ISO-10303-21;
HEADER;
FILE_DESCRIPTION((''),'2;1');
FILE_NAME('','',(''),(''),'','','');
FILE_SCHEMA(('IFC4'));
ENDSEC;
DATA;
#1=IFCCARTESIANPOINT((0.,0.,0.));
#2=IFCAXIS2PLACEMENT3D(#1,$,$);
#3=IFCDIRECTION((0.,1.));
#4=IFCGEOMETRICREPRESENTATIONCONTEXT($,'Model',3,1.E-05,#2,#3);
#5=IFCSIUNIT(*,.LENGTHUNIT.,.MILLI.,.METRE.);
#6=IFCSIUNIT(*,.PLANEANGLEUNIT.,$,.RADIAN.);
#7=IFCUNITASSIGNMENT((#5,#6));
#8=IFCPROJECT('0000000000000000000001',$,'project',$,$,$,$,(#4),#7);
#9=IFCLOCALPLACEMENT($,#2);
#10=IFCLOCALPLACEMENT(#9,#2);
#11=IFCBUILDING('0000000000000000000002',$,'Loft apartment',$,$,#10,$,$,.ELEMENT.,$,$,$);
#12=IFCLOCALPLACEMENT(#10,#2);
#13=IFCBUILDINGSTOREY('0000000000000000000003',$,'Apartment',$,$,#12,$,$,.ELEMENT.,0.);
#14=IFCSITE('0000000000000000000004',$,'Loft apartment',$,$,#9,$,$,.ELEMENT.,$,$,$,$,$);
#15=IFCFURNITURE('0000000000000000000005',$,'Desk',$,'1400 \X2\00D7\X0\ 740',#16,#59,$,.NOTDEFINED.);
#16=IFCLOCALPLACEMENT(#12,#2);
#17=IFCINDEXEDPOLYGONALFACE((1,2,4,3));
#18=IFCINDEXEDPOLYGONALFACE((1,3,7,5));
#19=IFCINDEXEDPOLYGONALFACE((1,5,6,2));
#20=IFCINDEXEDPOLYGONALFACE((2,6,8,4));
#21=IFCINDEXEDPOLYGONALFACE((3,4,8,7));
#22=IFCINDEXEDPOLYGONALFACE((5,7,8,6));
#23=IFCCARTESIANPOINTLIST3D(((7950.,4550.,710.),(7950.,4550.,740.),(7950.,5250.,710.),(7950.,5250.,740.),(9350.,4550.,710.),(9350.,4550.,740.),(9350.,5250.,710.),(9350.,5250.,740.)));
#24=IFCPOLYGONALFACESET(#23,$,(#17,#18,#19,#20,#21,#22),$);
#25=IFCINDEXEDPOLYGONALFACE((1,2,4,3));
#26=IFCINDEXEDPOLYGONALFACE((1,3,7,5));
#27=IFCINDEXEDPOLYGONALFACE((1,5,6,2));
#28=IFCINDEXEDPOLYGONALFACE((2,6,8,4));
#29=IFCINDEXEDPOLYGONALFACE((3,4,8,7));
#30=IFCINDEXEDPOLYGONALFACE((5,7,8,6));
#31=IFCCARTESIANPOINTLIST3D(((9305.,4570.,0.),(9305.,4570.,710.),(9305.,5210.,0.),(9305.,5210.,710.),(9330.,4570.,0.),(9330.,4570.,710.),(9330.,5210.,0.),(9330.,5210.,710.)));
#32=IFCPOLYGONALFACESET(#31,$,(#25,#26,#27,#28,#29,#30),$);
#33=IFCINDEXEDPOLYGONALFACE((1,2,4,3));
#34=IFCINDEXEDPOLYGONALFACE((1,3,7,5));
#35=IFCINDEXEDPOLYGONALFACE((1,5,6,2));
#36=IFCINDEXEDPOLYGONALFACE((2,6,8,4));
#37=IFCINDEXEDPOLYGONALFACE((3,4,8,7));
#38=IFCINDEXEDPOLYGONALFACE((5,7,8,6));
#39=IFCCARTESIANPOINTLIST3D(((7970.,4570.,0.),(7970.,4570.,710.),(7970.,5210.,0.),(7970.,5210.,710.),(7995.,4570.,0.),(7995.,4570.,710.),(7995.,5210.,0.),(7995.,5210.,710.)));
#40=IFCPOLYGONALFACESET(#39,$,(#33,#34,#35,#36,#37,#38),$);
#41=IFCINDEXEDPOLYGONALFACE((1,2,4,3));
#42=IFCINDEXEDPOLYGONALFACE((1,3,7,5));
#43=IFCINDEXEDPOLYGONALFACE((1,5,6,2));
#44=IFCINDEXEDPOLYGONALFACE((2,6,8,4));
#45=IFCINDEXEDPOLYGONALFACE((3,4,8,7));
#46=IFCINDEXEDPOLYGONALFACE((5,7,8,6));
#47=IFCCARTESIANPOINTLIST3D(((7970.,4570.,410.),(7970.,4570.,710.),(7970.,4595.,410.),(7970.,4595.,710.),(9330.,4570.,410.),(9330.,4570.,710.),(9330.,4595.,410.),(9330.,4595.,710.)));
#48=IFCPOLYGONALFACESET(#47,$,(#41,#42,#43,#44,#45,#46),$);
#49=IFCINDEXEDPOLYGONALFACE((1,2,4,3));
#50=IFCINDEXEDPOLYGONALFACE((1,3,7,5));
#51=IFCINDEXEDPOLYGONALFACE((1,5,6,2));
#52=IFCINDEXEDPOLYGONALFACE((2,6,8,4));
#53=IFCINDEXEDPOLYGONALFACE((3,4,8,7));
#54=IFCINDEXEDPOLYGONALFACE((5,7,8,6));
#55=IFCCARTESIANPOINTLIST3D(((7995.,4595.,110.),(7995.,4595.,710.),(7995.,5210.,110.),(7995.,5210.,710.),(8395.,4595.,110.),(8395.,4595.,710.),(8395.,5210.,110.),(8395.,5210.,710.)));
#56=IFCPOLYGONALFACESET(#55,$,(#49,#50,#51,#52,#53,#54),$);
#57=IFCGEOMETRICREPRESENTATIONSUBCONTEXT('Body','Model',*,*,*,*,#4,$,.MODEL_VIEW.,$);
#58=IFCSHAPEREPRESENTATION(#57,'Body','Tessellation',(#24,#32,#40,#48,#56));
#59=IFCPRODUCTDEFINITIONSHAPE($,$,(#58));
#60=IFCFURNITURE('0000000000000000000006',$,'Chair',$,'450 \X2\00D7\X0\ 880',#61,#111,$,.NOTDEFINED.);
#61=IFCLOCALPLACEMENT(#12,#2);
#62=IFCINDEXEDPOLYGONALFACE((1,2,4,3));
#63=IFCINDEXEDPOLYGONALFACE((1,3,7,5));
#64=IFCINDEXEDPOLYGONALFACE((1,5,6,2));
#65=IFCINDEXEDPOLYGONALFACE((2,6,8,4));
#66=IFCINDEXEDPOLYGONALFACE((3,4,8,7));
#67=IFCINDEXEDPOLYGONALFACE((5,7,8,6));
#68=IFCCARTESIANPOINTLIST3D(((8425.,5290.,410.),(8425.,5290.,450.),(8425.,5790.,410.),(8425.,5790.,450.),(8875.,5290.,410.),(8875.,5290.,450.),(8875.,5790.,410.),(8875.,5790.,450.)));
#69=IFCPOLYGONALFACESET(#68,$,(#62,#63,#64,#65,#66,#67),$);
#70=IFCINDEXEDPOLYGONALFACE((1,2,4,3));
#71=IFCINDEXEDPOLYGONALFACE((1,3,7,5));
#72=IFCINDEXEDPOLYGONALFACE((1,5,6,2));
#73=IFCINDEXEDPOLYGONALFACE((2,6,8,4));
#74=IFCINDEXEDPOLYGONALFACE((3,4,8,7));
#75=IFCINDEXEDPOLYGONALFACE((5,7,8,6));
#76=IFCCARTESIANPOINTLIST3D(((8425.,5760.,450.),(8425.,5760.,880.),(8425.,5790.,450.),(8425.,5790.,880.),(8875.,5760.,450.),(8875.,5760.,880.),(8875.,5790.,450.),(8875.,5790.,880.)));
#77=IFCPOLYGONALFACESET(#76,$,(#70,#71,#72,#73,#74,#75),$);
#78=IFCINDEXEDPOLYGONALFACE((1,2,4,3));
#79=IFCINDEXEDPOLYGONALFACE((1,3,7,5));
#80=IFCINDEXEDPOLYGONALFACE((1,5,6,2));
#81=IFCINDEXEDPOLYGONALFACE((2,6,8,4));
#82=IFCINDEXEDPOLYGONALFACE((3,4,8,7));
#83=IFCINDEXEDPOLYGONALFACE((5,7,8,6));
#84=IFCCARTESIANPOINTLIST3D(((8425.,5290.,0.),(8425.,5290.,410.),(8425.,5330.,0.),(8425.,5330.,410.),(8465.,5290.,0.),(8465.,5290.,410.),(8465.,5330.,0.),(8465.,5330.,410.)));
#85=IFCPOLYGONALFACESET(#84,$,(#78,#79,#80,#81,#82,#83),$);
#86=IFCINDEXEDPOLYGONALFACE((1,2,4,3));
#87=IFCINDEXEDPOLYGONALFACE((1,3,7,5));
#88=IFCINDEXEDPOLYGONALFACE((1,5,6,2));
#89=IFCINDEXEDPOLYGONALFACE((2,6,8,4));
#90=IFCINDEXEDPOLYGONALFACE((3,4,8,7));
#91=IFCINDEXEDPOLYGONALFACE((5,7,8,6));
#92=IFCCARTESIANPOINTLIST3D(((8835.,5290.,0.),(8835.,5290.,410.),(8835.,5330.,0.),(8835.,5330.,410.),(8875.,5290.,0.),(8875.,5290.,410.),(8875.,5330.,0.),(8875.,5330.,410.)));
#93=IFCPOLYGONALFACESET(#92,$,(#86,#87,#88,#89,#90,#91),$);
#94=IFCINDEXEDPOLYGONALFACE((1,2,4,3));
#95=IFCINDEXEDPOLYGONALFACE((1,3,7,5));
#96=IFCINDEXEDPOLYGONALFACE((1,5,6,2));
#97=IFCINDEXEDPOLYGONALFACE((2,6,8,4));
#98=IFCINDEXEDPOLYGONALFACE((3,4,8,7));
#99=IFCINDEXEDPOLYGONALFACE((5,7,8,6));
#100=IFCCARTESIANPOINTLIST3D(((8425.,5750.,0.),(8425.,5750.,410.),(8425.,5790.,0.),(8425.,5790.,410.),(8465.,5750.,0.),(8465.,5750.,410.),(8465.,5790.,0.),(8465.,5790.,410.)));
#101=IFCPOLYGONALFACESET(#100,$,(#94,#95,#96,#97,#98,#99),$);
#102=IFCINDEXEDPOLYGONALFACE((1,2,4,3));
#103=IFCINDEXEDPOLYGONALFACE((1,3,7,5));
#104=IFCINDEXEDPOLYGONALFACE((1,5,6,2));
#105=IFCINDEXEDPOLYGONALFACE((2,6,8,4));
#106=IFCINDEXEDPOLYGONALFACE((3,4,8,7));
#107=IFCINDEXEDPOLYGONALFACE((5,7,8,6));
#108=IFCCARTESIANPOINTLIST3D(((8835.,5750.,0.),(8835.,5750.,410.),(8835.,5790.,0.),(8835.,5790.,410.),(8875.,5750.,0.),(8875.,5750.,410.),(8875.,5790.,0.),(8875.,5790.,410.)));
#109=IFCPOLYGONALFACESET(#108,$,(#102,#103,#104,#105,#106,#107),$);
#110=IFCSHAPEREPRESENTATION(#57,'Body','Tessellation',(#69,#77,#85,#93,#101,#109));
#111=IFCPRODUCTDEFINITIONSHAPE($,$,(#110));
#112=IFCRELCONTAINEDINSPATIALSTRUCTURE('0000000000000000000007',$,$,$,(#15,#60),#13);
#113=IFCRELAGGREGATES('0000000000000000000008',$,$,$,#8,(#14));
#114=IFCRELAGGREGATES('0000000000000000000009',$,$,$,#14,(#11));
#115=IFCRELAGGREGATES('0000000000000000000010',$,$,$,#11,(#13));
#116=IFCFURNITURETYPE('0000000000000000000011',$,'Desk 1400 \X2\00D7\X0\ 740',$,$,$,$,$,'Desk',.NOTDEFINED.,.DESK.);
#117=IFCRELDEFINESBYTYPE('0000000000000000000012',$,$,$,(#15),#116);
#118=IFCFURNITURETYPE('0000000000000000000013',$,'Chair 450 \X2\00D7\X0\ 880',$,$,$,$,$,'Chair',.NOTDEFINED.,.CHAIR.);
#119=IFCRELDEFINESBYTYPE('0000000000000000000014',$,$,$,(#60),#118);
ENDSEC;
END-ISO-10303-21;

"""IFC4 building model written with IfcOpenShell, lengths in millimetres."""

from ifc_helpers import new_model, si_unit, direction, frame, origin, place, context, subcontext, project, spatial, polyline, outline, extrude, source, transform, mapped, type_object, type_shapes, element, save


model = new_model("IFC4")

# Units and contexts
model_context = context("Model", 3, precision=1e-05, world=origin(), true_north=direction((0.0, 1.0)))
body_context = subcontext(model_context, "Body", "Model", "MODEL_VIEW")
ifc_project = project(units=[si_unit("LENGTHUNIT", "METRE", prefix="MILLI"), si_unit("PLANEANGLEUNIT", "RADIAN")], contexts=[model_context])

# Site, building, storey
site_placement = place(None, origin())
site = spatial("IfcSite", under=ifc_project, at=site_placement, Name="Loft apartment", CompositionType="ELEMENT")
building_placement = place(site_placement, origin())
building = spatial("IfcBuilding", under=site, at=building_placement, Name="Loft apartment", CompositionType="ELEMENT")
storey_placement = place(building_placement, origin())
storey = spatial("IfcBuildingStorey", under=building, at=storey_placement, Name="Apartment", CompositionType="ELEMENT", Elevation=0.0)

# Furniture
furniture_type_1 = type_object("IfcFurnitureType", Name="Desk 1400 × 740", ElementType="Desk", AssemblyPlace="NOTDEFINED", PredefinedType="DESK")
shared_shape_1 = source(origin(), body_context, "Body", "SweptSolid", [
    extrude(outline(polyline([(-700.0, 0.0), (700.0, 0.0), (700.0, 700.0), (-700.0, 700.0), (-700.0, 0.0)])), frame((0.0, 0.0, 710.0)), (0.0, 0.0, 1.0), 30.0),
    extrude(outline(polyline([(-680.0, 40.0), (-655.0, 40.0), (-655.0, 680.0), (-680.0, 680.0), (-680.0, 40.0)])), origin(), (0.0, 0.0, 1.0), 710.0),
    extrude(outline(polyline([(655.0, 40.0), (680.0, 40.0), (680.0, 680.0), (655.0, 680.0), (655.0, 40.0)])), origin(), (0.0, 0.0, 1.0), 710.0),
    extrude(outline(polyline([(-680.0, 655.0), (680.0, 655.0), (680.0, 680.0), (-680.0, 680.0), (-680.0, 655.0)])), frame((0.0, 0.0, 410.0)), (0.0, 0.0, 1.0), 300.0),
    extrude(outline(polyline([(255.0, 40.0), (655.0, 40.0), (655.0, 655.0), (255.0, 655.0), (255.0, 40.0)])), frame((0.0, 0.0, 110.0)), (0.0, 0.0, 1.0), 600.0),
])
type_shapes(furniture_type_1, [shared_shape_1])
furniture_1_placement = place(storey_placement, frame((8650.0, 5250.0, 0.0), z_axis=(0.0, 0.0, 1.0), x_axis=(-1.0, 0.0, 0.0)))
element("IfcFurniture", 1, at=furniture_1_placement, inside=storey, type_object=furniture_type_1, Name="Desk", ObjectType="1400 × 740", PredefinedType="NOTDEFINED", context=body_context, shape_type="MappedRepresentation", body=[
    mapped(shared_shape_1, transform((0.0, 0.0, 0.0))),
])
furniture_type_2 = type_object("IfcFurnitureType", Name="Chair 450 × 880", ElementType="Chair", AssemblyPlace="NOTDEFINED", PredefinedType="CHAIR")
shared_shape_2 = source(origin(), body_context, "Body", "SweptSolid", [
    extrude(outline(polyline([(-225.0, 0.0), (225.0, 0.0), (225.0, 500.0), (-225.0, 500.0), (-225.0, 0.0)])), frame((0.0, 0.0, 410.0)), (0.0, 0.0, 1.0), 40.0),
    extrude(outline(polyline([(-225.0, 470.0), (225.0, 470.0), (225.0, 500.0), (-225.0, 500.0), (-225.0, 470.0)])), frame((0.0, 0.0, 450.0)), (0.0, 0.0, 1.0), 430.0),
    extrude(outline(polyline([(-225.0, 0.0), (-185.0, 0.0), (-185.0, 40.0), (-225.0, 40.0), (-225.0, 0.0)])), origin(), (0.0, 0.0, 1.0), 410.0),
    extrude(outline(polyline([(185.0, 0.0), (225.0, 0.0), (225.0, 40.0), (185.0, 40.0), (185.0, 0.0)])), origin(), (0.0, 0.0, 1.0), 410.0),
    extrude(outline(polyline([(-225.0, 460.0), (-185.0, 460.0), (-185.0, 500.0), (-225.0, 500.0), (-225.0, 460.0)])), origin(), (0.0, 0.0, 1.0), 410.0),
    extrude(outline(polyline([(185.0, 460.0), (225.0, 460.0), (225.0, 500.0), (185.0, 500.0), (185.0, 460.0)])), origin(), (0.0, 0.0, 1.0), 410.0),
])
type_shapes(furniture_type_2, [shared_shape_2])
furniture_2_placement = place(storey_placement, frame((8650.0, 5290.0, 0.0), z_axis=(0.0, 0.0, 1.0), x_axis=(1.0, 0.0, 0.0)))
element("IfcFurniture", 2, at=furniture_2_placement, inside=storey, type_object=furniture_type_2, Name="Chair", ObjectType="450 × 880", PredefinedType="NOTDEFINED", context=body_context, shape_type="MappedRepresentation", body=[
    mapped(shared_shape_2, transform((0.0, 0.0, 0.0))),
])

save(model, "model.ifc")
